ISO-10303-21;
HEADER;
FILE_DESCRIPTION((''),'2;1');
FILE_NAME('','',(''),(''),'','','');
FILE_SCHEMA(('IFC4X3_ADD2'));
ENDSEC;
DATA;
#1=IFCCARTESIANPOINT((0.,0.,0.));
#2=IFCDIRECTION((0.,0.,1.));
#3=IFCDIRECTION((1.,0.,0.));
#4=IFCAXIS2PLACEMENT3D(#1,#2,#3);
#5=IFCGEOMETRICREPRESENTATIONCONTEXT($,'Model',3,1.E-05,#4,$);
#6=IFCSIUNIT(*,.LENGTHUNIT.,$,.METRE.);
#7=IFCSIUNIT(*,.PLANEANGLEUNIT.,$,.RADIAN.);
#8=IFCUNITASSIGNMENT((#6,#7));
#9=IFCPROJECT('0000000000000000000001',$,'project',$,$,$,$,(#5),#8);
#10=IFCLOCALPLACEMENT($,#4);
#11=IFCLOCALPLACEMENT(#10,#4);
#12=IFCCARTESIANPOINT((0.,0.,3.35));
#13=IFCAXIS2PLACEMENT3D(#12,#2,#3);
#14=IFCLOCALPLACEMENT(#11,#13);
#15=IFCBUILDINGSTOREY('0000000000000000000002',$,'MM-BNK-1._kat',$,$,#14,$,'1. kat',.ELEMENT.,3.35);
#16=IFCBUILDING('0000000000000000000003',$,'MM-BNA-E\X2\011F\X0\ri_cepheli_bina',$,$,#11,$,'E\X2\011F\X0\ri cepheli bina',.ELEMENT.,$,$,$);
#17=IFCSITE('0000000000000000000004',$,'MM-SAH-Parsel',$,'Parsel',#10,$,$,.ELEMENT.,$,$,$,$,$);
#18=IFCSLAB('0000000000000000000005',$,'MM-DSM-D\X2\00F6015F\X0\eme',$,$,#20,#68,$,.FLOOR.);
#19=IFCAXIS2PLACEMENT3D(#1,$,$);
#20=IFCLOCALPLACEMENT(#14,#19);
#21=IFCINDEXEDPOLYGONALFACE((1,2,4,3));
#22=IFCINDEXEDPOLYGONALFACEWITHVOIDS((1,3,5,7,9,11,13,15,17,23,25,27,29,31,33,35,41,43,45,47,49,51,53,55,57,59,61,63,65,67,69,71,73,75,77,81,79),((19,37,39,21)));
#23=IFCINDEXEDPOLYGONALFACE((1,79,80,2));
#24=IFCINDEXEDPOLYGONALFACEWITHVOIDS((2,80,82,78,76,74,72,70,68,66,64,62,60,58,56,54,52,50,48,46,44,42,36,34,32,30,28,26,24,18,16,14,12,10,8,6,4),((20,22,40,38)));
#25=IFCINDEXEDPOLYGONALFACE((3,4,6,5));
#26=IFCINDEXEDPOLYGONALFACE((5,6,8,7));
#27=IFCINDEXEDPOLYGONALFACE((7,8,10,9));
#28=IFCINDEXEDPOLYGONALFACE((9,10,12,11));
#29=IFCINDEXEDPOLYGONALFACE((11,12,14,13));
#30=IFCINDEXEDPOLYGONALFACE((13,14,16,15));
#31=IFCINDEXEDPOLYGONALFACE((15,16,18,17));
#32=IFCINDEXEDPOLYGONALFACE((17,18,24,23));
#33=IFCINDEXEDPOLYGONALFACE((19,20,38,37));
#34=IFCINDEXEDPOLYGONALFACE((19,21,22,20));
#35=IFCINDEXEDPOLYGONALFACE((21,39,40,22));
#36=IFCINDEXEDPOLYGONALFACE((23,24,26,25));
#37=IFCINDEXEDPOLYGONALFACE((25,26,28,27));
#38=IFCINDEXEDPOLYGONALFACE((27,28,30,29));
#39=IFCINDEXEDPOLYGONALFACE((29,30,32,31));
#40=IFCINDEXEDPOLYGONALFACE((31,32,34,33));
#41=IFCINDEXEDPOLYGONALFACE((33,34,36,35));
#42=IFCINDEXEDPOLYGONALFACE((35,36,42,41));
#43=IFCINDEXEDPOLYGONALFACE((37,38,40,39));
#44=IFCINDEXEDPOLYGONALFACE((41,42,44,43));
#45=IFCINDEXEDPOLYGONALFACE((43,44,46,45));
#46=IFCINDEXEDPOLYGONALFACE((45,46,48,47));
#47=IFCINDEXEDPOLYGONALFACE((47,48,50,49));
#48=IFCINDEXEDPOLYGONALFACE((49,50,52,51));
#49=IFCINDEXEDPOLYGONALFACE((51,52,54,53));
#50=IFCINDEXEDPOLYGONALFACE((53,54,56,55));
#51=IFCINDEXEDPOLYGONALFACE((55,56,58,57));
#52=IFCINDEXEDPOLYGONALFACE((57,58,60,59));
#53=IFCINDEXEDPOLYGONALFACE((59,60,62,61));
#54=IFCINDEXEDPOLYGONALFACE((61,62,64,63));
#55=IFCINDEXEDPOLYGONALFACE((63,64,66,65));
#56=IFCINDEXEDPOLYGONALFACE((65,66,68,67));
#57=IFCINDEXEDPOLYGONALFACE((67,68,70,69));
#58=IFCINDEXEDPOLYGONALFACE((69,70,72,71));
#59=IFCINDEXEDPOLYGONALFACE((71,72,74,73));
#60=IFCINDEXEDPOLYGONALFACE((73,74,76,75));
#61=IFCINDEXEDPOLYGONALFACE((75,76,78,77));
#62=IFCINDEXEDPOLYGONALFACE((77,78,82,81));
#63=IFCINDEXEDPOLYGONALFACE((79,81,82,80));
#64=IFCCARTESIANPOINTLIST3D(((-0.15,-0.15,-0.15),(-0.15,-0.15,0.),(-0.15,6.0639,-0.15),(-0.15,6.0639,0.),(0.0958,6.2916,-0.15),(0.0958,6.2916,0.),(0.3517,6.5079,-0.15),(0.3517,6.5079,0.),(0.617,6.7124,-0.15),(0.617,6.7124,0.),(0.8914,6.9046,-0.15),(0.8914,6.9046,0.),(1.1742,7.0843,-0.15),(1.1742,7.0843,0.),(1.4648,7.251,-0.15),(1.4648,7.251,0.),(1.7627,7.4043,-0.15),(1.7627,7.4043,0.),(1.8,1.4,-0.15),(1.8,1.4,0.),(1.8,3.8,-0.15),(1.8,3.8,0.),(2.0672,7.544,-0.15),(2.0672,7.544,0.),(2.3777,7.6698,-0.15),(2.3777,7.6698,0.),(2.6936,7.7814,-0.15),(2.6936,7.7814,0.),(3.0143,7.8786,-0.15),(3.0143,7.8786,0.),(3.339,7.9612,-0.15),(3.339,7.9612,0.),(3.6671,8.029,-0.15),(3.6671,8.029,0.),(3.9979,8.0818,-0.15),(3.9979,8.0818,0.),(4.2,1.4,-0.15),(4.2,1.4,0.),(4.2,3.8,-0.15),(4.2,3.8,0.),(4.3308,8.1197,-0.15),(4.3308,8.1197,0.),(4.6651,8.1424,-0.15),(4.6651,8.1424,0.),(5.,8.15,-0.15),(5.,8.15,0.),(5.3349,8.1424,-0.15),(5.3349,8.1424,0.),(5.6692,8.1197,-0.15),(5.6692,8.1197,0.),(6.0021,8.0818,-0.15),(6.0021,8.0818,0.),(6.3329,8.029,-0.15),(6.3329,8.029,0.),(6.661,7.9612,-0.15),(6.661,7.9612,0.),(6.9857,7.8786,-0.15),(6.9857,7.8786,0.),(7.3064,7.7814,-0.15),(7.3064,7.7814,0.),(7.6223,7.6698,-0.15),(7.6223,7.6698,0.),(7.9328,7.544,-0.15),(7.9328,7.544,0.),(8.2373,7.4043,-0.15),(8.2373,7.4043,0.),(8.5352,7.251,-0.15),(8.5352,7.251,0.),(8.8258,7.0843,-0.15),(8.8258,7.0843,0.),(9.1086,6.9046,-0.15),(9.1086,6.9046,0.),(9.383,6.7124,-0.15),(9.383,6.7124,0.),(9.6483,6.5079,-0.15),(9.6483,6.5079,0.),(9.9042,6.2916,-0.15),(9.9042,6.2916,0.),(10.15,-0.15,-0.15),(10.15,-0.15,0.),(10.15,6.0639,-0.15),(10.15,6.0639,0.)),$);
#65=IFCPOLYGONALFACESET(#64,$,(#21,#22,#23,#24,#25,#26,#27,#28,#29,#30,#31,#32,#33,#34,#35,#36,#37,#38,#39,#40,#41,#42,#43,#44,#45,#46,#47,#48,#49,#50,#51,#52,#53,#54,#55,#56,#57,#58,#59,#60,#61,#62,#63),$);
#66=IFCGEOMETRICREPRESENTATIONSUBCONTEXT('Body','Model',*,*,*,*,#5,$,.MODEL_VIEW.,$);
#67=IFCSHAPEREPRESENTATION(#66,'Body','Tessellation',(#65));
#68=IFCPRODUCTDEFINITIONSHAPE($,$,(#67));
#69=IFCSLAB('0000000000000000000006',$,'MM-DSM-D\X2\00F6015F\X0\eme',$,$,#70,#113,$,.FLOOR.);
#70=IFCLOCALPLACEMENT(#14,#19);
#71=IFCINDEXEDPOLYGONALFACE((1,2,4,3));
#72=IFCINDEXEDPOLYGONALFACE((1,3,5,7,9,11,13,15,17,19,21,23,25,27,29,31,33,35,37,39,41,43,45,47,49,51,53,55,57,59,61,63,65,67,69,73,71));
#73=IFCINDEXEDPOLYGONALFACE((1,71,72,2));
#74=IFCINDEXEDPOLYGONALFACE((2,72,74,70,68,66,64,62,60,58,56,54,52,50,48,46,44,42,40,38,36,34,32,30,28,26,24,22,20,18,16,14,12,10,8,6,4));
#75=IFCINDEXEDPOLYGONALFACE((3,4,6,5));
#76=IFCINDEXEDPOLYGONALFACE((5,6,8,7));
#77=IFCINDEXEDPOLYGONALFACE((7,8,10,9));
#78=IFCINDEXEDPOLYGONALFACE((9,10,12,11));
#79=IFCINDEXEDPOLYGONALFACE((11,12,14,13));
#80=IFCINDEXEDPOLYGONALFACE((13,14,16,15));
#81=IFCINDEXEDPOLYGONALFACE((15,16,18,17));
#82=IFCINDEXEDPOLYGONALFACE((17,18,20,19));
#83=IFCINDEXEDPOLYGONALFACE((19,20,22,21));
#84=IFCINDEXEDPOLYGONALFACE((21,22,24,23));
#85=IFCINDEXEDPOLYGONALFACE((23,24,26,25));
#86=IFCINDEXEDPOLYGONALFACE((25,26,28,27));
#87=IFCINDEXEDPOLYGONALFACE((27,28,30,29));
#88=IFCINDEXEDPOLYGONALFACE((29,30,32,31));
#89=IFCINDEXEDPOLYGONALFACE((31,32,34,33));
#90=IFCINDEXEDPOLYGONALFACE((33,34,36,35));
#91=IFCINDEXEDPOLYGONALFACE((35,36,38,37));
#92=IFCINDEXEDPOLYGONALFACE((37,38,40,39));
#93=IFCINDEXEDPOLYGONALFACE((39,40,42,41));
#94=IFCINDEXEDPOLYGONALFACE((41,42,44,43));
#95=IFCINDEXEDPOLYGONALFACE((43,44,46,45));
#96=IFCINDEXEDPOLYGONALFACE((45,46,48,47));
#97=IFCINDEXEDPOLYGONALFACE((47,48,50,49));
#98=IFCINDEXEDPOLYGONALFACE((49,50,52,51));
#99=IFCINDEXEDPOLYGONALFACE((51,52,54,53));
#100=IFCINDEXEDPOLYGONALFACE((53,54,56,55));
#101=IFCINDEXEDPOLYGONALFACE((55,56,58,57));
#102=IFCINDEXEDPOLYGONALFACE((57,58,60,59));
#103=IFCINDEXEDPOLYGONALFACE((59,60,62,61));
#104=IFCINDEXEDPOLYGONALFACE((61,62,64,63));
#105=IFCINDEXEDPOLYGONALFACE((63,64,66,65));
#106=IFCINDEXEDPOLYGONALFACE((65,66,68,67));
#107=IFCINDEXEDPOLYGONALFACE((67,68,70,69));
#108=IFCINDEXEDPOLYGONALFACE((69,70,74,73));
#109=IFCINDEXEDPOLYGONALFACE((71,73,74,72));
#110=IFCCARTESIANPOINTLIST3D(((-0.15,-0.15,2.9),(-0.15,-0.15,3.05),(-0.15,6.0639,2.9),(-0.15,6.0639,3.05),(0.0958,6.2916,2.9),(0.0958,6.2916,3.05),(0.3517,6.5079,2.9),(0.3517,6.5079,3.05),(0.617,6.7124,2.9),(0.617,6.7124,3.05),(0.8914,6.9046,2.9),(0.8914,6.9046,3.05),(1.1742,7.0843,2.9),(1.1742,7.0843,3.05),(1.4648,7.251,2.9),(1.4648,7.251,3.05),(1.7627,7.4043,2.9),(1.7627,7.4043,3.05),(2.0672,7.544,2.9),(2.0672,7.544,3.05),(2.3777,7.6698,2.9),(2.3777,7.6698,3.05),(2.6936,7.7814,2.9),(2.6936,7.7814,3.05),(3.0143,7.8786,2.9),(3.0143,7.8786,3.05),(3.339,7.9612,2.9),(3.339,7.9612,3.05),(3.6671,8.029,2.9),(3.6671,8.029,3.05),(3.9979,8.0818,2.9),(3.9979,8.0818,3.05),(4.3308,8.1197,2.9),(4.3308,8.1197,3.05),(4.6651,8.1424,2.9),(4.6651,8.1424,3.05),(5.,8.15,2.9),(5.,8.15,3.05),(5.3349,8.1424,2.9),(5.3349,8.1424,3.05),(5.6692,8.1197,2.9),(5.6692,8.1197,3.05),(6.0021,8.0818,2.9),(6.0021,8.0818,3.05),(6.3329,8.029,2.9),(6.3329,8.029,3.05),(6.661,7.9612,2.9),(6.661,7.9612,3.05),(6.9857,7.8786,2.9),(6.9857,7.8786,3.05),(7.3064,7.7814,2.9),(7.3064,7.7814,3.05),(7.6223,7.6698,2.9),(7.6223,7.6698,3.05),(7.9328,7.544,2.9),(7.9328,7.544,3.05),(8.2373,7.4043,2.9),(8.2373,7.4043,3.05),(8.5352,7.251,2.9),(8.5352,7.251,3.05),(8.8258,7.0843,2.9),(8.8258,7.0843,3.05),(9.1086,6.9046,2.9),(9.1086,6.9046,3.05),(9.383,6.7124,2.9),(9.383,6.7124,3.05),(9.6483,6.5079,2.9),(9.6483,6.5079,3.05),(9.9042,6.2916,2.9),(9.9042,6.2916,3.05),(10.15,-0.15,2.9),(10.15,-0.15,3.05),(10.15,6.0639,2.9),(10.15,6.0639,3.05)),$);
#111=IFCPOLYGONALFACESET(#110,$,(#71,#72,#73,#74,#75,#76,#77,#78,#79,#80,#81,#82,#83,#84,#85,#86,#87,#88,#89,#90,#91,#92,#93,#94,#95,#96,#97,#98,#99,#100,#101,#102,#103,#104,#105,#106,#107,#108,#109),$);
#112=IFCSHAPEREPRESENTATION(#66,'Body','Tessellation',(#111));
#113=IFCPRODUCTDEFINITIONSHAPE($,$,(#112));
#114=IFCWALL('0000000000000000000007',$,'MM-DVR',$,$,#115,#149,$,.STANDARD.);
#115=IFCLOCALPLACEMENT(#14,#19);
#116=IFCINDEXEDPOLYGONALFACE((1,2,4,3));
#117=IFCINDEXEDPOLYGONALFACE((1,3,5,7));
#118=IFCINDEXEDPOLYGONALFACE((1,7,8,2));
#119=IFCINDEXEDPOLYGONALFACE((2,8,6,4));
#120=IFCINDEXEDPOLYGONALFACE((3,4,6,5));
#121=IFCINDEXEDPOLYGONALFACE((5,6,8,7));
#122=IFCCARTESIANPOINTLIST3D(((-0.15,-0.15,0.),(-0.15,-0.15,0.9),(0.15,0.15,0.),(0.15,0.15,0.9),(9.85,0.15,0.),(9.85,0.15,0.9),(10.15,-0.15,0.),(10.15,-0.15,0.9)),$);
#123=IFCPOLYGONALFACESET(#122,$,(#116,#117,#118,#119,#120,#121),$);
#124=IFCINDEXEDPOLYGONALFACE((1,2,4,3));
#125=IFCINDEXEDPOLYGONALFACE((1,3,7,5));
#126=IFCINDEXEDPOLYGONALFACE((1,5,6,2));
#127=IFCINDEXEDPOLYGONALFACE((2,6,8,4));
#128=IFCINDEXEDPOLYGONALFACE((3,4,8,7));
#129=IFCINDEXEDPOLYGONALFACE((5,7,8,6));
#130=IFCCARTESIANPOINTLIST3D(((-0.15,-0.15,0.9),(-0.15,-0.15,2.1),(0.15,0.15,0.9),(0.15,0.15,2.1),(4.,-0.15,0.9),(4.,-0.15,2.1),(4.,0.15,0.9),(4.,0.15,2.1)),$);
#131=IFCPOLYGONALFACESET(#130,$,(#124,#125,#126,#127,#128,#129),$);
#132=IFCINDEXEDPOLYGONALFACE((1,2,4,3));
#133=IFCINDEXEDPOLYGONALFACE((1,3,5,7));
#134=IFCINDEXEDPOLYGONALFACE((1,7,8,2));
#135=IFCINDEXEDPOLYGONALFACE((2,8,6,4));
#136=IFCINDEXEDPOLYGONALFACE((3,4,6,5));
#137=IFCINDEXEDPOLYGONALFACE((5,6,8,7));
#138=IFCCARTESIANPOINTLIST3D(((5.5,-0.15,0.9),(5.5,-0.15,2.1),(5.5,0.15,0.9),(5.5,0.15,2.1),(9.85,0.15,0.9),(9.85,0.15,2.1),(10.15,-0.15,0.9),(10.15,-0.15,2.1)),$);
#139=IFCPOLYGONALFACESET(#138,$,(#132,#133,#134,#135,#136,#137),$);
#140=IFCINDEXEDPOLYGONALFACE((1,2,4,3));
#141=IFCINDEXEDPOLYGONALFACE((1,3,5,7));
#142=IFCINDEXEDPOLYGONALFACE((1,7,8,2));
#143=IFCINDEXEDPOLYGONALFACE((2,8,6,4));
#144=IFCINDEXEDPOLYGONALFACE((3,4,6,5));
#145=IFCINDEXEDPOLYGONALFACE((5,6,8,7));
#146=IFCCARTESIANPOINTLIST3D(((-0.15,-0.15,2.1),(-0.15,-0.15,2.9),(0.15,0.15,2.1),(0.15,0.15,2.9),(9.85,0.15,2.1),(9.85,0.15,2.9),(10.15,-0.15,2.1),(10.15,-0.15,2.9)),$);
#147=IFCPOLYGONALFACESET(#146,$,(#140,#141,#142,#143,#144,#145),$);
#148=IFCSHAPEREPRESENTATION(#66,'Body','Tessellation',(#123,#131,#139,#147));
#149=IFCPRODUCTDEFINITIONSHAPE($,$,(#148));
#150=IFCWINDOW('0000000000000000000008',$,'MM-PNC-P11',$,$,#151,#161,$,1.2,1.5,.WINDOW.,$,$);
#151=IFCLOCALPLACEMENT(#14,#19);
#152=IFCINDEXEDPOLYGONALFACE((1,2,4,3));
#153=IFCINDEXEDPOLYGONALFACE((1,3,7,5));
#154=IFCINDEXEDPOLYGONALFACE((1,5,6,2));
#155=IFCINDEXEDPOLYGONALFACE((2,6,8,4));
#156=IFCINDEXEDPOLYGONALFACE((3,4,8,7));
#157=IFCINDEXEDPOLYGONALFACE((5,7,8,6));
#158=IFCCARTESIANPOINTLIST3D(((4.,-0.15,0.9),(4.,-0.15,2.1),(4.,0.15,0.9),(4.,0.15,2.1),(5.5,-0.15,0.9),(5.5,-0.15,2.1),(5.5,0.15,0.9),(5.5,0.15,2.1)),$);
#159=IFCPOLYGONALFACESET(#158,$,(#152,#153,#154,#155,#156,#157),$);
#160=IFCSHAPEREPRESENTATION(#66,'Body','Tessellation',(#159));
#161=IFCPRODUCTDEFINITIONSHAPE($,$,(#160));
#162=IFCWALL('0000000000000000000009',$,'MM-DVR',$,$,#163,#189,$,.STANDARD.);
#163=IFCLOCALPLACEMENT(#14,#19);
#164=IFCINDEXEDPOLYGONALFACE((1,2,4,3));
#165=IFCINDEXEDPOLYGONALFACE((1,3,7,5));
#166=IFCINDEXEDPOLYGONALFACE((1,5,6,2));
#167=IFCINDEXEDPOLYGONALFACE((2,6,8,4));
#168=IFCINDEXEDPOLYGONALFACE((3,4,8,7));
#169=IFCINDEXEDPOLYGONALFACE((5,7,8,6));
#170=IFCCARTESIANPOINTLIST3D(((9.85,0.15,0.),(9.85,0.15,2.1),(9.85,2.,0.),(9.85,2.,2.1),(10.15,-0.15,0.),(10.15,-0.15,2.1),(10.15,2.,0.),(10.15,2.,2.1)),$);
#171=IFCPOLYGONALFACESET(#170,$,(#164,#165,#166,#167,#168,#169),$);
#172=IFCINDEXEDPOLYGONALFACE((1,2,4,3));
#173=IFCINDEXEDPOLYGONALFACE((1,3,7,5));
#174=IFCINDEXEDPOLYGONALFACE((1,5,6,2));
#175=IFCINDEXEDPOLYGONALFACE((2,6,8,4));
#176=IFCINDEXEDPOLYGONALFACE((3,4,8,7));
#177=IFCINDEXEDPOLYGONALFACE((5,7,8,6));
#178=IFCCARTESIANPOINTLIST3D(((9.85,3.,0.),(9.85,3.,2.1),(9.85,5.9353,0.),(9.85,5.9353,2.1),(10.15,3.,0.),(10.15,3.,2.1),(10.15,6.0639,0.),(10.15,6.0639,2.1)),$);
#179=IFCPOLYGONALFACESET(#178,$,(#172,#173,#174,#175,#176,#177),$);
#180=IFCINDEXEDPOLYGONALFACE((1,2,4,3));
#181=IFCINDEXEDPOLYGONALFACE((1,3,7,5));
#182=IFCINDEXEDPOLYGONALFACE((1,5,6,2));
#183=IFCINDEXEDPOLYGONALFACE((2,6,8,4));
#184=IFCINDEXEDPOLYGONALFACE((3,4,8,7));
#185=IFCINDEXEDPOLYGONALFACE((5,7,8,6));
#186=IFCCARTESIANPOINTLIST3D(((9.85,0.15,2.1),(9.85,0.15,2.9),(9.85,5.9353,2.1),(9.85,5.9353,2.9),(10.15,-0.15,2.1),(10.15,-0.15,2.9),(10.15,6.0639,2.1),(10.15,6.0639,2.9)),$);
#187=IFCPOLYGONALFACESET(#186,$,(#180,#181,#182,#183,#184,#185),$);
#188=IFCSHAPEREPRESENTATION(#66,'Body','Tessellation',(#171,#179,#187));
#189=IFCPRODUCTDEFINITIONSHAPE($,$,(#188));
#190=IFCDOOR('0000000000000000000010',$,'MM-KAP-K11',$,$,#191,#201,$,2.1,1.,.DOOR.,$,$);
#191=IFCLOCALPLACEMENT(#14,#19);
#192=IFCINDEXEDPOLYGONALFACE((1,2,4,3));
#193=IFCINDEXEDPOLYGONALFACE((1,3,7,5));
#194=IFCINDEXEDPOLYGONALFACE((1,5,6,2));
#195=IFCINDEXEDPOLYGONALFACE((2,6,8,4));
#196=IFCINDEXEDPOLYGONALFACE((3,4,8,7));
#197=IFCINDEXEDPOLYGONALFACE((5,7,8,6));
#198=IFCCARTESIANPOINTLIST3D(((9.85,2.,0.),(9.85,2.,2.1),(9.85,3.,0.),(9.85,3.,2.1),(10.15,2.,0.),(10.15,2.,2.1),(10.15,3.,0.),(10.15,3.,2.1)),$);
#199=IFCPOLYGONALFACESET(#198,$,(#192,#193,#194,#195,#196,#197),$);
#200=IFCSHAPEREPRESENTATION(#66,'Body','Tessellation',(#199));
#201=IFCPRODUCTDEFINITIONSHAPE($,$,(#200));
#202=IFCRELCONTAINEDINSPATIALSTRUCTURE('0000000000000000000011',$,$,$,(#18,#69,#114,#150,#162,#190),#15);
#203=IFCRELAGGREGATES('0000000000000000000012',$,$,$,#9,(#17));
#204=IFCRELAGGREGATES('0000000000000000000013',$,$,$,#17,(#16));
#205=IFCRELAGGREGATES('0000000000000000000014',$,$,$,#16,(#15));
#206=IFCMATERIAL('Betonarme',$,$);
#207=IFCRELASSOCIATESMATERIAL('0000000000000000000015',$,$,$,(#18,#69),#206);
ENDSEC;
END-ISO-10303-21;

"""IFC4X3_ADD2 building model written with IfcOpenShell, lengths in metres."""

from ifc_helpers import new_model, si_unit, frame, origin, origin_with_axes, place, context, subcontext, project, spatial, polyline, line, arc, indexed_curve, outline, extrude, material, element, fill, save


model = new_model("IFC4X3_ADD2")

# Units and contexts
model_context = context("Model", 3, precision=1e-05, world=origin_with_axes())
body_context = subcontext(model_context, "Body", "Model", "MODEL_VIEW")
ifc_project = project(units=[si_unit("LENGTHUNIT", "METRE"), si_unit("PLANEANGLEUNIT", "RADIAN")], contexts=[model_context])

# Site, building, storey
site_placement = place(None, origin_with_axes())
site = spatial("IfcSite", under=ifc_project, at=site_placement, Name="MM-SAH-Parsel", ObjectType="Parsel", CompositionType="ELEMENT")
building_placement = place(site_placement, origin_with_axes())
building = spatial("IfcBuilding", under=site, at=building_placement, Name="MM-BNA-Eğri_cepheli_bina", LongName="Eğri cepheli bina", CompositionType="ELEMENT")
storey_placement = place(building_placement, frame((0.0, 0.0, 3.35), z_axis=(0.0, 0.0, 1.0), x_axis=(1.0, 0.0, 0.0)))
storey = spatial("IfcBuildingStorey", under=building, at=storey_placement, Name="MM-BNK-1._kat", LongName="1. kat", CompositionType="ELEMENT", Elevation=3.35)

# Slab, opening
ifc_material = material(Name="Betonarme")
slab_1_placement = place(storey_placement, origin_with_axes())
slab_1 = element("IfcSlab", 1, at=slab_1_placement, inside=storey, material=ifc_material, Name="MM-DSM-Döşeme", PredefinedType="FLOOR", context=body_context, shape_type="SweptSolid", body=[
    extrude(outline(indexed_curve([(-0.15, -0.15), (10.15, -0.15), (10.15, 6.0639), (5.0, 8.15), (-0.15, 6.0639)], segments=[line(1, 2, 3), arc(3, 4, 5), line(5, 1)], self_intersect=False), holes=[polyline([(4.2, 1.4), (1.8, 1.4), (1.8, 3.8), (4.2, 3.8), (4.2, 1.4)])]), frame((0.0, 0.0, -0.15)), (0.0, 0.0, 1.0), 0.15),
])
opening_1_placement = place(storey_placement, origin_with_axes())
element("IfcOpeningElement", 2, at=opening_1_placement, cuts=slab_1, PredefinedType="OPENING", context=body_context, identifier="Reference", shape_type="SweptSolid", body=[
    extrude(outline(polyline([(1.8, 1.4), (4.2, 1.4), (4.2, 3.8), (1.8, 3.8), (1.8, 1.4)])), frame((0.0, 0.0, -0.15)), (0.0, 0.0, 1.0), 0.15),
])

# Slab
slab_2_placement = place(storey_placement, origin_with_axes())
element("IfcSlab", 3, at=slab_2_placement, inside=storey, material=ifc_material, Name="MM-DSM-Döşeme", PredefinedType="FLOOR", context=body_context, shape_type="SweptSolid", body=[
    extrude(outline(indexed_curve([(-0.15, -0.15), (10.15, -0.15), (10.15, 6.0639), (5.0, 8.15), (-0.15, 6.0639)], segments=[line(1, 2, 3), arc(3, 4, 5), line(5, 1)], self_intersect=False)), frame((0.0, 0.0, 2.9)), (0.0, 0.0, 1.0), 0.15),
])

# Wall, opening, window
wall_1_placement = place(storey_placement, origin_with_axes())
wall_1 = element("IfcWall", 4, at=wall_1_placement, inside=storey, Name="MM-DVR", PredefinedType="STANDARD", context=body_context, shape_type="SweptSolid", body=[
    extrude(outline(polyline([(0.15, 0.15), (9.85, 0.15), (10.15, -0.15), (-0.15, -0.15), (0.15, 0.15)])), origin(), (0.0, 0.0, 1.0), 0.9),
    extrude(outline(polyline([(-0.15, -0.15), (4.0, -0.15), (4.0, 0.15), (0.15, 0.15), (-0.15, -0.15)])), frame((0.0, 0.0, 0.9)), (0.0, 0.0, 1.0), 1.2),
    extrude(outline(polyline([(5.5, -0.15), (10.15, -0.15), (9.85, 0.15), (5.5, 0.15), (5.5, -0.15)])), frame((0.0, 0.0, 0.9)), (0.0, 0.0, 1.0), 1.2),
    extrude(outline(polyline([(0.15, 0.15), (9.85, 0.15), (10.15, -0.15), (-0.15, -0.15), (0.15, 0.15)])), frame((0.0, 0.0, 2.1)), (0.0, 0.0, 1.0), 0.8),
])
opening_2_placement = place(storey_placement, origin_with_axes())
opening_2 = element("IfcOpeningElement", 5, at=opening_2_placement, cuts=wall_1, PredefinedType="OPENING", context=body_context, identifier="Reference", shape_type="SweptSolid", body=[
    extrude(outline(polyline([(4.0, 0.15), (5.5, 0.15), (5.5, -0.15), (4.0, -0.15), (4.0, 0.15)])), frame((0.0, 0.0, 0.9)), (0.0, 0.0, 1.0), 1.2),
])
window_1_placement = place(storey_placement, origin_with_axes())
window_1 = element("IfcWindow", 6, at=window_1_placement, inside=storey, Name="MM-PNC-P11", OverallHeight=1.2, OverallWidth=1.5, PredefinedType="WINDOW", context=body_context, shape_type="SweptSolid", body=[
    extrude(outline(polyline([(4.0, 0.15), (5.5, 0.15), (5.5, -0.15), (4.0, -0.15), (4.0, 0.15)])), frame((0.0, 0.0, 0.9)), (0.0, 0.0, 1.0), 1.2),
])
fill(opening_2, window_1)

# Wall, opening, door
wall_2_placement = place(storey_placement, origin_with_axes())
wall_2 = element("IfcWall", 7, at=wall_2_placement, inside=storey, Name="MM-DVR", PredefinedType="STANDARD", context=body_context, shape_type="SweptSolid", body=[
    extrude(outline(polyline([(10.15, -0.15), (10.15, 2.0), (9.85, 2.0), (9.85, 0.15), (10.15, -0.15)])), origin(), (0.0, 0.0, 1.0), 2.1),
    extrude(outline(polyline([(10.15, 3.0), (10.15, 6.0639), (9.85, 5.9353), (9.85, 3.0), (10.15, 3.0)])), origin(), (0.0, 0.0, 1.0), 2.1),
    extrude(outline(polyline([(9.85, 0.15), (9.85, 5.9353), (10.15, 6.0639), (10.15, -0.15), (9.85, 0.15)])), frame((0.0, 0.0, 2.1)), (0.0, 0.0, 1.0), 0.8),
])
opening_3_placement = place(storey_placement, origin_with_axes())
opening_3 = element("IfcOpeningElement", 8, at=opening_3_placement, cuts=wall_2, PredefinedType="OPENING", context=body_context, identifier="Reference", shape_type="SweptSolid", body=[
    extrude(outline(polyline([(9.85, 2.0), (9.85, 3.0), (10.15, 3.0), (10.15, 2.0), (9.85, 2.0)])), origin(), (0.0, 0.0, 1.0), 2.1),
])
door_placement = place(storey_placement, origin_with_axes())
door = element("IfcDoor", 9, at=door_placement, inside=storey, Name="MM-KAP-K11", OverallHeight=2.1, OverallWidth=1.0, PredefinedType="DOOR", context=body_context, shape_type="SweptSolid", body=[
    extrude(outline(polyline([(9.85, 2.0), (9.85, 3.0), (10.15, 3.0), (10.15, 2.0), (9.85, 2.0)])), origin(), (0.0, 0.0, 1.0), 2.1),
])
fill(opening_3, door)

save(model, "model.ifc")
